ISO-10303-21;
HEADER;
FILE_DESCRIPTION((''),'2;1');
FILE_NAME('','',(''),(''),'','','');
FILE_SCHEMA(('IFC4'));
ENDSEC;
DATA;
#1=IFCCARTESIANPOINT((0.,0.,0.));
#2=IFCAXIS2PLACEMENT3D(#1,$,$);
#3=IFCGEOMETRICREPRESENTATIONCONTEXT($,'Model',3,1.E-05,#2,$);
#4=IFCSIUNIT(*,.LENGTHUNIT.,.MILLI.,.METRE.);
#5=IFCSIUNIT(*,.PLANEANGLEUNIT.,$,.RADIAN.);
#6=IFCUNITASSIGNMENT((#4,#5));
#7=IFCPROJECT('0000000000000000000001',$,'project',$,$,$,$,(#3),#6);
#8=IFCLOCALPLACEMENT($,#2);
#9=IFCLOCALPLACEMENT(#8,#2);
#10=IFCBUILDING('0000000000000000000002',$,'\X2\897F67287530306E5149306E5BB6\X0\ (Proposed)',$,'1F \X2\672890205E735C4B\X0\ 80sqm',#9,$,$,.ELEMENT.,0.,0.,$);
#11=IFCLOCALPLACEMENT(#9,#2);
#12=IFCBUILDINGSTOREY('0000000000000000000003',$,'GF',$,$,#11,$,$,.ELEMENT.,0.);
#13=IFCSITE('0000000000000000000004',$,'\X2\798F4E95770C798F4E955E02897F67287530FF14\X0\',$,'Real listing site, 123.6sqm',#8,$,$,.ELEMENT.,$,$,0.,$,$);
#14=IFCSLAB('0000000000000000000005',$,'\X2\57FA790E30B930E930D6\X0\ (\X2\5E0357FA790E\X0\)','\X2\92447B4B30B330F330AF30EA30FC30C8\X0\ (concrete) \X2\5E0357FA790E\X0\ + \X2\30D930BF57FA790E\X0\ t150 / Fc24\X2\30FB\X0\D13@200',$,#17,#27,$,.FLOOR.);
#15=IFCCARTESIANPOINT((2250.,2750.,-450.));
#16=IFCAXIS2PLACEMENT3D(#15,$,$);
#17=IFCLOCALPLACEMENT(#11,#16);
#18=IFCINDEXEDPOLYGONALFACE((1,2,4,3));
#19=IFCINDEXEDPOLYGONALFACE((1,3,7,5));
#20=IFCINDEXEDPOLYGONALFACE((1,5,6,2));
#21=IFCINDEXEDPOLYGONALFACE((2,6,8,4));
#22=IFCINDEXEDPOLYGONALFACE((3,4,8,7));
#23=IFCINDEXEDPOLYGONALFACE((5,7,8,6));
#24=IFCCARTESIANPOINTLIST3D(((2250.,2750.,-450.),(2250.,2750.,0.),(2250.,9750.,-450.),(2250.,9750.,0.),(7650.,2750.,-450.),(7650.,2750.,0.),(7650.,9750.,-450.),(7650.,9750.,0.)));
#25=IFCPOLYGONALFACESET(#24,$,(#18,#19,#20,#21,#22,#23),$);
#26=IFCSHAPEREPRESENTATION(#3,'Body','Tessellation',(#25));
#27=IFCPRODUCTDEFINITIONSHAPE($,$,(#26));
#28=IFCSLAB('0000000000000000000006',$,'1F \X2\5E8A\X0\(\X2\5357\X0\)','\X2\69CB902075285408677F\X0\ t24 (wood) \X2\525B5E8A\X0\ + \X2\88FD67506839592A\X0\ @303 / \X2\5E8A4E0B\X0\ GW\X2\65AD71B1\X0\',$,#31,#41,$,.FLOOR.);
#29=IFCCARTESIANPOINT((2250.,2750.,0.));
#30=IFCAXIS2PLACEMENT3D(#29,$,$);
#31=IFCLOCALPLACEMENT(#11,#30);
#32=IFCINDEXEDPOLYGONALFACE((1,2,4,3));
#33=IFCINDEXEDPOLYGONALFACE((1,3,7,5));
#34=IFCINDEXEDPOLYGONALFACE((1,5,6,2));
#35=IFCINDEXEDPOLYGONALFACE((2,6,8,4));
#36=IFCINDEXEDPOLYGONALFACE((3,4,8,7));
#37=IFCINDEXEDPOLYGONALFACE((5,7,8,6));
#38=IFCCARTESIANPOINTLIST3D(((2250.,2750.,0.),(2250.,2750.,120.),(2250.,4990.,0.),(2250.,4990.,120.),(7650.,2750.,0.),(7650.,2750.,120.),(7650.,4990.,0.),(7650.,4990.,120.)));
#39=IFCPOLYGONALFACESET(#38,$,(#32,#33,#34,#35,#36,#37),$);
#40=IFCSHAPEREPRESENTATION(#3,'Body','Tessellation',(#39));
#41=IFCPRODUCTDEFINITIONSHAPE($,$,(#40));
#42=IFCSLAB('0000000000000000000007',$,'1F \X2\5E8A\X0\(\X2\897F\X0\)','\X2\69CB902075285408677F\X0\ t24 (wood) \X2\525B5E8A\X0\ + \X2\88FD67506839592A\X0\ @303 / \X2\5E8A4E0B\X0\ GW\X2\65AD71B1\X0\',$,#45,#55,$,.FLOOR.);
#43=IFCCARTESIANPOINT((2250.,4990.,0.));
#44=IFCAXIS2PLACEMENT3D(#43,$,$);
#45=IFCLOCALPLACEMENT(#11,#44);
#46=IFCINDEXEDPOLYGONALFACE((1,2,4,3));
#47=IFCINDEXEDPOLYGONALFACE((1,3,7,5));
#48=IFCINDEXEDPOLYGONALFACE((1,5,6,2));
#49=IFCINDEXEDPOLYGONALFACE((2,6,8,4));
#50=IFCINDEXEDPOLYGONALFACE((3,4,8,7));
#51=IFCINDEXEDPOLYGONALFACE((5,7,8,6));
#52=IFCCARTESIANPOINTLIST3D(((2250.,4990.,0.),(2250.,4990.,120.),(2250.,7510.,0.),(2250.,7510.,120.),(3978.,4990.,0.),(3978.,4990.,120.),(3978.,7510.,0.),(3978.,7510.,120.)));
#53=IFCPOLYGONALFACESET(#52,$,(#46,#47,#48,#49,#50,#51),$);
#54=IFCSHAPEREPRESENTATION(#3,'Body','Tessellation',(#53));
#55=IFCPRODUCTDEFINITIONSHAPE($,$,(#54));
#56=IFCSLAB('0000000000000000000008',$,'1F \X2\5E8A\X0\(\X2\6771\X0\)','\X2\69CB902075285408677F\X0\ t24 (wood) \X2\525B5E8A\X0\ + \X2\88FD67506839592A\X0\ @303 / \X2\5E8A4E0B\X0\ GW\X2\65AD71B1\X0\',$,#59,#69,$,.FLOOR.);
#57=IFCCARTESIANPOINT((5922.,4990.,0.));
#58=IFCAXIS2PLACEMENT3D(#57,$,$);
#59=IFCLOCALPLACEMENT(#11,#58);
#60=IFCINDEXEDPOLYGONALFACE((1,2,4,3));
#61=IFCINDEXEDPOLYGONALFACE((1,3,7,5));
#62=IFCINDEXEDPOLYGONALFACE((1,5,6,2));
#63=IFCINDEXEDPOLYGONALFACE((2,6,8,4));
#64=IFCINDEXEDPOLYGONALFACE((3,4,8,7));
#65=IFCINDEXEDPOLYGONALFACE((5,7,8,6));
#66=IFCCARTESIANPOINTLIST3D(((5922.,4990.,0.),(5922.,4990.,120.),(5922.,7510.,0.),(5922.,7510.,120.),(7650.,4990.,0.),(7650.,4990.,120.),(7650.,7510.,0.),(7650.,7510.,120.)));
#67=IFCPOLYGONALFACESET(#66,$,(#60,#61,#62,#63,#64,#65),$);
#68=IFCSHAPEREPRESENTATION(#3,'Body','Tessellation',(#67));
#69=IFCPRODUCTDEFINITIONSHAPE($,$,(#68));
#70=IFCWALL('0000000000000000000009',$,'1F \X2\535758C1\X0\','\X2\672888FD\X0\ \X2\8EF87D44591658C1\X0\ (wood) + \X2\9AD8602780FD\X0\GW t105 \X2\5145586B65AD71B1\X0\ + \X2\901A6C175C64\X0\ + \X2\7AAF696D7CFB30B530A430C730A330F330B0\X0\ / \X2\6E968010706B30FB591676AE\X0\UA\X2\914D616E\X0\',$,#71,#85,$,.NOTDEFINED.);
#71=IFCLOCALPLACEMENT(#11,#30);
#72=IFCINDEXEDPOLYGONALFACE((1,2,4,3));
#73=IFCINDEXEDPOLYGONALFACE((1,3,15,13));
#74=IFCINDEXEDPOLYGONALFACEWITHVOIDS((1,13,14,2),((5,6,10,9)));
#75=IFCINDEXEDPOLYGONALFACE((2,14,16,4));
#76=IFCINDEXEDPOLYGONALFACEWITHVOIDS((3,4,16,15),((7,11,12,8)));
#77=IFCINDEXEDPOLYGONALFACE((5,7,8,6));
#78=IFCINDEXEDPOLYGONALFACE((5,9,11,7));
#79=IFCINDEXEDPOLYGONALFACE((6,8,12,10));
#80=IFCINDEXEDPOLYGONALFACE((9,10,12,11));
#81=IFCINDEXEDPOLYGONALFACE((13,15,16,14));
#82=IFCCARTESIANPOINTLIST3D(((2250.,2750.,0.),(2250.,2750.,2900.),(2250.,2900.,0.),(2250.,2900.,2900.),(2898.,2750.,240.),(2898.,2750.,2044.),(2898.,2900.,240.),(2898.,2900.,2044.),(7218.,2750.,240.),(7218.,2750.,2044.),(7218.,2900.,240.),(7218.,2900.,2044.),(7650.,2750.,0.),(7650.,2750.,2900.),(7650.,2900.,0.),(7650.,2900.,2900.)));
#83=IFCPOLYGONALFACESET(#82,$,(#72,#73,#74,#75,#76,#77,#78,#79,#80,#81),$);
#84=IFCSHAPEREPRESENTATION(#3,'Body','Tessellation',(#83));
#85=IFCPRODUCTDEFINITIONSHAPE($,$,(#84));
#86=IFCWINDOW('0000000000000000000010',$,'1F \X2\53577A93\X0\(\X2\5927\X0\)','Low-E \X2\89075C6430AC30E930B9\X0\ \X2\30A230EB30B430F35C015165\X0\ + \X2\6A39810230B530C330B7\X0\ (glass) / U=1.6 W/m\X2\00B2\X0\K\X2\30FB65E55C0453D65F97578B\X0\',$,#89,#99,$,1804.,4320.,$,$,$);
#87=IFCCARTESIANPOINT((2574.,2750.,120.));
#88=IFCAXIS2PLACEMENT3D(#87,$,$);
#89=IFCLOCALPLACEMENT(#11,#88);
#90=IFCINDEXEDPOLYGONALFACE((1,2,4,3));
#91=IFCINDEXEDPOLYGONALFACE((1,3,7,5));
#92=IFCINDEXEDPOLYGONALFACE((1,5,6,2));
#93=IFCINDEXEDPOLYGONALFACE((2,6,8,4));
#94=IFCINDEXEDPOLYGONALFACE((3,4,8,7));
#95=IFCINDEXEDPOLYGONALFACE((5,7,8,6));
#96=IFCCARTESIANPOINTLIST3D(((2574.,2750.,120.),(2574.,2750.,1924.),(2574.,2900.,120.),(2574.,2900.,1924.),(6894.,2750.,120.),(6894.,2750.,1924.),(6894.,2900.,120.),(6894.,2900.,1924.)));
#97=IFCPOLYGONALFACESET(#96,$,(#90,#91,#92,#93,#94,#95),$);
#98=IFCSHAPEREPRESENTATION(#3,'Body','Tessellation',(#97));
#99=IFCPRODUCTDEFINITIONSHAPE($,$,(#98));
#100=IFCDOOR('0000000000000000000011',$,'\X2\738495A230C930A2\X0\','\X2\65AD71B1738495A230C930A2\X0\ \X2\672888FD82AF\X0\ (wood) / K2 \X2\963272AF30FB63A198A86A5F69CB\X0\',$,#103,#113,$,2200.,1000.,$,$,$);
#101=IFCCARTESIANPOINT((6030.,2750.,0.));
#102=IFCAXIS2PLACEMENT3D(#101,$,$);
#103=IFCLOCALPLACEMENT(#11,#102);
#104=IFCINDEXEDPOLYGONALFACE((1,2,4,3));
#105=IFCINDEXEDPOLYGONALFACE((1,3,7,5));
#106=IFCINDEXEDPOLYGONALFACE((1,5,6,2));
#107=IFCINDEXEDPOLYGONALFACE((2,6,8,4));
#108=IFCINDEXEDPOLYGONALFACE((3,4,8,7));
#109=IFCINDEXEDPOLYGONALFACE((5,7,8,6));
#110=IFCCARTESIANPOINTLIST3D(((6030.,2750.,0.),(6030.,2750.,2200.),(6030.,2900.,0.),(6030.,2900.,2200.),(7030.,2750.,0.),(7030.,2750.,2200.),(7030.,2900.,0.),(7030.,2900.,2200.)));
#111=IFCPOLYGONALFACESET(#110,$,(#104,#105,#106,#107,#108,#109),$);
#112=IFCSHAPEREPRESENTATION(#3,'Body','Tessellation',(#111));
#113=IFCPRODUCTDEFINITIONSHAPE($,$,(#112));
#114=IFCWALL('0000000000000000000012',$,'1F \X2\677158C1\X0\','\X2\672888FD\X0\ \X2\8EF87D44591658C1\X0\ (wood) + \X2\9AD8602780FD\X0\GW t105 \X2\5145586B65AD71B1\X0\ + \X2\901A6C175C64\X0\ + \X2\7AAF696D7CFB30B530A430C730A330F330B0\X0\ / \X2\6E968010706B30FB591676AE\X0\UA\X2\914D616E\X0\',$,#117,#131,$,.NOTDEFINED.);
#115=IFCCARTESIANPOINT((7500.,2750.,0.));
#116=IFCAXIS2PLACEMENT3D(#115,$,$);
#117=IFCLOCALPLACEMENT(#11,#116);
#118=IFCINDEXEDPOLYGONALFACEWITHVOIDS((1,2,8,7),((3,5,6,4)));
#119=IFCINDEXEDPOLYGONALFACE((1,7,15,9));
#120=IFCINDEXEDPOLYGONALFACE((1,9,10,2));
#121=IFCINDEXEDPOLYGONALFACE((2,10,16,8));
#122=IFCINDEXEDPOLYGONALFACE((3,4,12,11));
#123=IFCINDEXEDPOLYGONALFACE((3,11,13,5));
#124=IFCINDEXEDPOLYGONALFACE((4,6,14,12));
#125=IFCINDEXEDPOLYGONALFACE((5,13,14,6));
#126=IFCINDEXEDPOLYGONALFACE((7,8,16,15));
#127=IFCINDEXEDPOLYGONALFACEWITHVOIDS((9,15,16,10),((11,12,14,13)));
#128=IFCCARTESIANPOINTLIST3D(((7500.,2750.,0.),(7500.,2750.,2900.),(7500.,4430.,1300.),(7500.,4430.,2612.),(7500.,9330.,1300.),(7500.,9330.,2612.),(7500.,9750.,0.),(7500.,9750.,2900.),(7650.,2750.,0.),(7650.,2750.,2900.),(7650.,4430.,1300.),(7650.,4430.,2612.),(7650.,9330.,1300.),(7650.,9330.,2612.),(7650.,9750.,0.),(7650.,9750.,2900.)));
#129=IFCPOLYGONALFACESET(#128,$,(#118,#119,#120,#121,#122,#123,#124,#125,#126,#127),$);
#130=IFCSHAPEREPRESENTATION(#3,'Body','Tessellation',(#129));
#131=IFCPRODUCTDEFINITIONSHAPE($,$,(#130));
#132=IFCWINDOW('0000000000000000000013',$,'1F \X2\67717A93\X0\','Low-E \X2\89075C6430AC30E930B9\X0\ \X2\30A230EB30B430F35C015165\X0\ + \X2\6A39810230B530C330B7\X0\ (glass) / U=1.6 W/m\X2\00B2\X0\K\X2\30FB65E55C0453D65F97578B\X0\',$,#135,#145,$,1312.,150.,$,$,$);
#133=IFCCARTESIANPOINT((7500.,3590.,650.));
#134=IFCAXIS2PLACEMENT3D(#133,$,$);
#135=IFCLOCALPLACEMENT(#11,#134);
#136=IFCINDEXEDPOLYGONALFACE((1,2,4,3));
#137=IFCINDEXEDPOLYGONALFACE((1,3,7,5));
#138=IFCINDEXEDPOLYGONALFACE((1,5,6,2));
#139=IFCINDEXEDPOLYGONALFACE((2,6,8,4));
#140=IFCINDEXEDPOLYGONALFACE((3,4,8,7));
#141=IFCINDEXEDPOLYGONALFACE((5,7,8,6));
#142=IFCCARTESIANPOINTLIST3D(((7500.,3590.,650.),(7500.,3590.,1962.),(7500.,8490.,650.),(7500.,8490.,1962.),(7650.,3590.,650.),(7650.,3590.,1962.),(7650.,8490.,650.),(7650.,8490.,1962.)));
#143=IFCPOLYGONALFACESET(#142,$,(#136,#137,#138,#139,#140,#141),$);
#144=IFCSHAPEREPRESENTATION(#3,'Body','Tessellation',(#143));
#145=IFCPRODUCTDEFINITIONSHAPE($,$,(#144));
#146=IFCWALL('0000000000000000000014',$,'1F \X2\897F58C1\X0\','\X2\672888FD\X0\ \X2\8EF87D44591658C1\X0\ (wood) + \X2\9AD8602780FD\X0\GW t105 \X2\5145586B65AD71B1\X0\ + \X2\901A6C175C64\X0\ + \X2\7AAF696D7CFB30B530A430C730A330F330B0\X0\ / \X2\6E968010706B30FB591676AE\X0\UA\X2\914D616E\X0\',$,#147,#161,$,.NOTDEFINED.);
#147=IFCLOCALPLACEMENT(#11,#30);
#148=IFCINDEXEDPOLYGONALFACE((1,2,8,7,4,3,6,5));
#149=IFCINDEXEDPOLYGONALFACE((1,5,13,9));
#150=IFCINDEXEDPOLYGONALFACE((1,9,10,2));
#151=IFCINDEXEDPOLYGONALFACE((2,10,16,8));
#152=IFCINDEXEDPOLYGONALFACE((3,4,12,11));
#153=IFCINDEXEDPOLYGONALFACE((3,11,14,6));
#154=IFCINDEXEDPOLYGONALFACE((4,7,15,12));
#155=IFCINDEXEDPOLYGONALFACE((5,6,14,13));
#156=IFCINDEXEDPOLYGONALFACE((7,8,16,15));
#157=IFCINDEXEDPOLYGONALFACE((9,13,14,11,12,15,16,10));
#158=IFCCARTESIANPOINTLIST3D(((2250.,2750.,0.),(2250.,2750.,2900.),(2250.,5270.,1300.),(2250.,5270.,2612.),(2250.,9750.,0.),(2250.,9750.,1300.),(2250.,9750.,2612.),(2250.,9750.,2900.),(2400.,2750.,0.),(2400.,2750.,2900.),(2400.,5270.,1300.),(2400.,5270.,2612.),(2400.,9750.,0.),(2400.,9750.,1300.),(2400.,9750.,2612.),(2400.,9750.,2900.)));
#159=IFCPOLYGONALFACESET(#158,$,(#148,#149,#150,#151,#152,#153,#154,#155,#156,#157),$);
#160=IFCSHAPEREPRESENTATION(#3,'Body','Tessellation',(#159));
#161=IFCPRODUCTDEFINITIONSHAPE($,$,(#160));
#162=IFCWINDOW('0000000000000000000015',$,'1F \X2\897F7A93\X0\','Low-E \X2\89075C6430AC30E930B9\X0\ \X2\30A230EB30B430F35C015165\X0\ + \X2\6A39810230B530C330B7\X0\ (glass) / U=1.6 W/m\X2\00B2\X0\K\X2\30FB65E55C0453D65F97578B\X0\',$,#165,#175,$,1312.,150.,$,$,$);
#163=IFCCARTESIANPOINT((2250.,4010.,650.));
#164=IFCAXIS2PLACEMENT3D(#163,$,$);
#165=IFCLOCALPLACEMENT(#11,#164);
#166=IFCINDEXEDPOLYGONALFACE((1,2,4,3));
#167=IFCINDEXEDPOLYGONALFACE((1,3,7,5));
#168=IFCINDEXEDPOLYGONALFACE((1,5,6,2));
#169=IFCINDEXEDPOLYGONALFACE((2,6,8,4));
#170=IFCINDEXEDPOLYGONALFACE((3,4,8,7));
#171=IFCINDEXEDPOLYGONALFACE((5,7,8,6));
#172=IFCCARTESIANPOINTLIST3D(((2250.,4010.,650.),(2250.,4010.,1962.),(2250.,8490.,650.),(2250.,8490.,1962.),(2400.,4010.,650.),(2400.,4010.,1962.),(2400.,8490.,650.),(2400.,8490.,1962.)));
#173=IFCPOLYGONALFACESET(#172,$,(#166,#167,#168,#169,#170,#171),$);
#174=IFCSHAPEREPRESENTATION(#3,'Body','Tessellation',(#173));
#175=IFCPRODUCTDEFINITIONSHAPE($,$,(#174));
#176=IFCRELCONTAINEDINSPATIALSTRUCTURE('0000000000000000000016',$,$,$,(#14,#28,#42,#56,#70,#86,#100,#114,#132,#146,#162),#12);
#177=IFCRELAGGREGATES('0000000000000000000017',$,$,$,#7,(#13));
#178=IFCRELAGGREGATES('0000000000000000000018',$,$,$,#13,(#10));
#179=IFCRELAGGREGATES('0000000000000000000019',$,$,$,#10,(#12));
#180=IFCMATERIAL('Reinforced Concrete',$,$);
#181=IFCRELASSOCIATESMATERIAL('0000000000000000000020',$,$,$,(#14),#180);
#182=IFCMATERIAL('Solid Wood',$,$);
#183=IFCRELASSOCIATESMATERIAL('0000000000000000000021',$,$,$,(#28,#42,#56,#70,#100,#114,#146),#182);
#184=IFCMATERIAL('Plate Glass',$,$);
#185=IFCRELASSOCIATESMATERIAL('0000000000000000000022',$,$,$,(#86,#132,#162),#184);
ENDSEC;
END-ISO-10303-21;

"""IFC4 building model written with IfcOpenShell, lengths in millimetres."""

from ifc_helpers import new_model, si_unit, frame, frame_2d, origin, place, context, project, spatial, rectangle, extrude, material, element, fill, save


model = new_model("IFC4")

# Units and contexts
model_context = context("Model", 3, precision=1e-05, world=origin())
ifc_project = project(units=[si_unit("LENGTHUNIT", "METRE", prefix="MILLI"), si_unit("PLANEANGLEUNIT", "RADIAN")], contexts=[model_context])

# Site, building, storey
site_placement = place(None, origin())
site = spatial("IfcSite", under=ifc_project, at=site_placement, Name="福井県福井市西木田４", ObjectType="Real listing site, 123.6sqm", CompositionType="ELEMENT", RefElevation=0.0)
building_placement = place(site_placement, origin())
building = spatial("IfcBuilding", under=site, at=building_placement, Name="西木田の光の家 (Proposed)", ObjectType="1F 木造平屋 80sqm", CompositionType="ELEMENT", ElevationOfRefHeight=0.0, ElevationOfTerrain=0.0)
storey_placement = place(building_placement, origin())
storey = spatial("IfcBuildingStorey", under=building, at=storey_placement, Name="GF", CompositionType="ELEMENT", Elevation=0.0)

# Slabs
ifc_material_1 = material(Name="Reinforced Concrete")
slab_1_placement = place(storey_placement, frame((2250.0, 2750.0, -450.0)))
element("IfcSlab", 1, at=slab_1_placement, inside=storey, material=ifc_material_1, Name="基礎スラブ (布基礎)", Description="鉄筋コンクリート (concrete) 布基礎 + ベタ基礎 t150 / Fc24・D13@200", PredefinedType="FLOOR", context=model_context, shape_type="SweptSolid", body=[
    extrude(rectangle(XDim=5400.0, YDim=7000.0, at=frame_2d((2700.0, 3500.0))), frame((2250.0, 2750.0, -450.0)), (0.0, 0.0, 1.0), 450.0),
])
ifc_material_2 = material(Name="Solid Wood")
slab_2_placement = place(storey_placement, frame((2250.0, 2750.0, 0.0)))
element("IfcSlab", 2, at=slab_2_placement, inside=storey, material=ifc_material_2, Name="1F 床(南)", Description="構造用合板 t24 (wood) 剛床 + 製材根太 @303 / 床下 GW断熱", PredefinedType="FLOOR", context=model_context, shape_type="SweptSolid", body=[
    extrude(rectangle(XDim=5400.0, YDim=2240.0, at=frame_2d((2700.0, 1120.0))), frame((2250.0, 2750.0, 0.0)), (0.0, 0.0, 1.0), 120.0),
])
slab_3_placement = place(storey_placement, frame((2250.0, 4990.0, 0.0)))
element("IfcSlab", 3, at=slab_3_placement, inside=storey, material=ifc_material_2, Name="1F 床(西)", Description="構造用合板 t24 (wood) 剛床 + 製材根太 @303 / 床下 GW断熱", PredefinedType="FLOOR", context=model_context, shape_type="SweptSolid", body=[
    extrude(rectangle(XDim=1728.0, YDim=2520.0, at=frame_2d((864.0, 1260.0))), frame((2250.0, 4990.0, 0.0)), (0.0, 0.0, 1.0), 120.0),
])
slab_4_placement = place(storey_placement, frame((5922.0, 4990.0, 0.0)))
element("IfcSlab", 4, at=slab_4_placement, inside=storey, material=ifc_material_2, Name="1F 床(東)", Description="構造用合板 t24 (wood) 剛床 + 製材根太 @303 / 床下 GW断熱", PredefinedType="FLOOR", context=model_context, shape_type="SweptSolid", body=[
    extrude(rectangle(XDim=1728.0, YDim=2520.0, at=frame_2d((864.0, 1260.0))), frame((5922.0, 4990.0, 0.0)), (0.0, 0.0, 1.0), 120.0),
])

# Wall, openings, window, door
wall_1_placement = place(storey_placement, frame((2250.0, 2750.0, 0.0)))
wall_1 = element("IfcWall", 5, at=wall_1_placement, inside=storey, material=ifc_material_2, Name="1F 南壁", Description="木製 軸組外壁 (wood) + 高性能GW t105 充填断熱 + 通気層 + 窯業系サイディング / 準耐火・外皮UA配慮", PredefinedType="NOTDEFINED", context=model_context, shape_type="SweptSolid", body=[
    extrude(rectangle(XDim=5400.0, YDim=150.0, at=frame_2d((2700.0, 75.0))), frame((2250.0, 2750.0, 0.0)), (0.0, 0.0, 1.0), 2900.0),
])
opening_1_placement = place(storey_placement, frame((2574.0, 2750.0, 120.0)))
opening_1 = element("IfcOpeningElement", 6, at=opening_1_placement, cuts=wall_1, PredefinedType="NOTDEFINED", context=model_context, shape_type="SweptSolid", body=[
    extrude(rectangle(XDim=4320.0, YDim=150.0, at=frame_2d((2160.0, 75.0))), frame((2574.0, 2750.0, 120.0)), (0.0, 0.0, 1.0), 1804.0),
])
opening_2_placement = place(storey_placement, frame((6030.0, 2750.0, 0.0)))
opening_2 = element("IfcOpeningElement", 7, at=opening_2_placement, cuts=wall_1, PredefinedType="NOTDEFINED", context=model_context, shape_type="SweptSolid", body=[
    extrude(rectangle(XDim=1000.0, YDim=150.0, at=frame_2d((500.0, 75.0))), frame((6030.0, 2750.0, 0.0)), (0.0, 0.0, 1.0), 2200.0),
])
ifc_material_3 = material(Name="Plate Glass")
window_1_placement = place(storey_placement, frame((2574.0, 2750.0, 120.0)))
window_1 = element("IfcWindow", 8, at=window_1_placement, inside=storey, material=ifc_material_3, Name="1F 南窓(大)", Description="Low-E 複層ガラス アルゴン封入 + 樹脂サッシ (glass) / U=1.6 W/m²K・日射取得型", OverallHeight=1804.0, OverallWidth=4320.0, context=model_context, shape_type="SweptSolid", body=[
    extrude(rectangle(XDim=4320.0, YDim=150.0, at=frame_2d((2160.0, 75.0))), frame((2574.0, 2750.0, 120.0)), (0.0, 0.0, 1.0), 1804.0),
])
fill(opening_1, window_1)
door_placement = place(storey_placement, frame((6030.0, 2750.0, 0.0)))
door = element("IfcDoor", 9, at=door_placement, inside=storey, material=ifc_material_2, Name="玄関ドア", Description="断熱玄関ドア 木製芯 (wood) / K2 防犯・採風機構", OverallHeight=2200.0, OverallWidth=1000.0, context=model_context, shape_type="SweptSolid", body=[
    extrude(rectangle(XDim=1000.0, YDim=150.0, at=frame_2d((500.0, 75.0))), frame((6030.0, 2750.0, 0.0)), (0.0, 0.0, 1.0), 2200.0),
])
fill(opening_2, door)

# Walls, openings, windows
wall_2_placement = place(storey_placement, frame((7500.0, 2750.0, 0.0)))
wall_2 = element("IfcWall", 10, at=wall_2_placement, inside=storey, material=ifc_material_2, Name="1F 東壁", Description="木製 軸組外壁 (wood) + 高性能GW t105 充填断熱 + 通気層 + 窯業系サイディング / 準耐火・外皮UA配慮", PredefinedType="NOTDEFINED", context=model_context, shape_type="SweptSolid", body=[
    extrude(rectangle(XDim=150.0, YDim=7000.0, at=frame_2d((75.0, 3500.0))), frame((7500.0, 2750.0, 0.0)), (0.0, 0.0, 1.0), 2900.0),
])
opening_3_placement = place(storey_placement, frame((7500.0, 3590.0, 650.0)))
opening_3 = element("IfcOpeningElement", 11, at=opening_3_placement, cuts=wall_2, PredefinedType="NOTDEFINED", context=model_context, shape_type="SweptSolid", body=[
    extrude(rectangle(XDim=150.0, YDim=4900.0, at=frame_2d((75.0, 2450.0))), frame((7500.0, 3590.0, 650.0)), (0.0, 0.0, 1.0), 1312.0),
])
window_2_placement = place(storey_placement, frame((7500.0, 3590.0, 650.0)))
window_2 = element("IfcWindow", 12, at=window_2_placement, inside=storey, material=ifc_material_3, Name="1F 東窓", Description="Low-E 複層ガラス アルゴン封入 + 樹脂サッシ (glass) / U=1.6 W/m²K・日射取得型", OverallHeight=1312.0, OverallWidth=150.0, context=model_context, shape_type="SweptSolid", body=[
    extrude(rectangle(XDim=150.0, YDim=4900.0, at=frame_2d((75.0, 2450.0))), frame((7500.0, 3590.0, 650.0)), (0.0, 0.0, 1.0), 1312.0),
])
fill(opening_3, window_2)
wall_3_placement = place(storey_placement, frame((2250.0, 2750.0, 0.0)))
wall_3 = element("IfcWall", 13, at=wall_3_placement, inside=storey, material=ifc_material_2, Name="1F 西壁", Description="木製 軸組外壁 (wood) + 高性能GW t105 充填断熱 + 通気層 + 窯業系サイディング / 準耐火・外皮UA配慮", PredefinedType="NOTDEFINED", context=model_context, shape_type="SweptSolid", body=[
    extrude(rectangle(XDim=150.0, YDim=7000.0, at=frame_2d((75.0, 3500.0))), frame((2250.0, 2750.0, 0.0)), (0.0, 0.0, 1.0), 2900.0),
])
opening_4_placement = place(storey_placement, frame((2250.0, 4010.0, 650.0)))
opening_4 = element("IfcOpeningElement", 14, at=opening_4_placement, cuts=wall_3, PredefinedType="NOTDEFINED", context=model_context, shape_type="SweptSolid", body=[
    extrude(rectangle(XDim=150.0, YDim=4480.0, at=frame_2d((75.0, 2240.0))), frame((2250.0, 4010.0, 650.0)), (0.0, 0.0, 1.0), 1312.0),
])
window_3_placement = place(storey_placement, frame((2250.0, 4010.0, 650.0)))
window_3 = element("IfcWindow", 15, at=window_3_placement, inside=storey, material=ifc_material_3, Name="1F 西窓", Description="Low-E 複層ガラス アルゴン封入 + 樹脂サッシ (glass) / U=1.6 W/m²K・日射取得型", OverallHeight=1312.0, OverallWidth=150.0, context=model_context, shape_type="SweptSolid", body=[
    extrude(rectangle(XDim=150.0, YDim=4480.0, at=frame_2d((75.0, 2240.0))), frame((2250.0, 4010.0, 650.0)), (0.0, 0.0, 1.0), 1312.0),
])
fill(opening_4, window_3)

save(model, "model.ifc")
